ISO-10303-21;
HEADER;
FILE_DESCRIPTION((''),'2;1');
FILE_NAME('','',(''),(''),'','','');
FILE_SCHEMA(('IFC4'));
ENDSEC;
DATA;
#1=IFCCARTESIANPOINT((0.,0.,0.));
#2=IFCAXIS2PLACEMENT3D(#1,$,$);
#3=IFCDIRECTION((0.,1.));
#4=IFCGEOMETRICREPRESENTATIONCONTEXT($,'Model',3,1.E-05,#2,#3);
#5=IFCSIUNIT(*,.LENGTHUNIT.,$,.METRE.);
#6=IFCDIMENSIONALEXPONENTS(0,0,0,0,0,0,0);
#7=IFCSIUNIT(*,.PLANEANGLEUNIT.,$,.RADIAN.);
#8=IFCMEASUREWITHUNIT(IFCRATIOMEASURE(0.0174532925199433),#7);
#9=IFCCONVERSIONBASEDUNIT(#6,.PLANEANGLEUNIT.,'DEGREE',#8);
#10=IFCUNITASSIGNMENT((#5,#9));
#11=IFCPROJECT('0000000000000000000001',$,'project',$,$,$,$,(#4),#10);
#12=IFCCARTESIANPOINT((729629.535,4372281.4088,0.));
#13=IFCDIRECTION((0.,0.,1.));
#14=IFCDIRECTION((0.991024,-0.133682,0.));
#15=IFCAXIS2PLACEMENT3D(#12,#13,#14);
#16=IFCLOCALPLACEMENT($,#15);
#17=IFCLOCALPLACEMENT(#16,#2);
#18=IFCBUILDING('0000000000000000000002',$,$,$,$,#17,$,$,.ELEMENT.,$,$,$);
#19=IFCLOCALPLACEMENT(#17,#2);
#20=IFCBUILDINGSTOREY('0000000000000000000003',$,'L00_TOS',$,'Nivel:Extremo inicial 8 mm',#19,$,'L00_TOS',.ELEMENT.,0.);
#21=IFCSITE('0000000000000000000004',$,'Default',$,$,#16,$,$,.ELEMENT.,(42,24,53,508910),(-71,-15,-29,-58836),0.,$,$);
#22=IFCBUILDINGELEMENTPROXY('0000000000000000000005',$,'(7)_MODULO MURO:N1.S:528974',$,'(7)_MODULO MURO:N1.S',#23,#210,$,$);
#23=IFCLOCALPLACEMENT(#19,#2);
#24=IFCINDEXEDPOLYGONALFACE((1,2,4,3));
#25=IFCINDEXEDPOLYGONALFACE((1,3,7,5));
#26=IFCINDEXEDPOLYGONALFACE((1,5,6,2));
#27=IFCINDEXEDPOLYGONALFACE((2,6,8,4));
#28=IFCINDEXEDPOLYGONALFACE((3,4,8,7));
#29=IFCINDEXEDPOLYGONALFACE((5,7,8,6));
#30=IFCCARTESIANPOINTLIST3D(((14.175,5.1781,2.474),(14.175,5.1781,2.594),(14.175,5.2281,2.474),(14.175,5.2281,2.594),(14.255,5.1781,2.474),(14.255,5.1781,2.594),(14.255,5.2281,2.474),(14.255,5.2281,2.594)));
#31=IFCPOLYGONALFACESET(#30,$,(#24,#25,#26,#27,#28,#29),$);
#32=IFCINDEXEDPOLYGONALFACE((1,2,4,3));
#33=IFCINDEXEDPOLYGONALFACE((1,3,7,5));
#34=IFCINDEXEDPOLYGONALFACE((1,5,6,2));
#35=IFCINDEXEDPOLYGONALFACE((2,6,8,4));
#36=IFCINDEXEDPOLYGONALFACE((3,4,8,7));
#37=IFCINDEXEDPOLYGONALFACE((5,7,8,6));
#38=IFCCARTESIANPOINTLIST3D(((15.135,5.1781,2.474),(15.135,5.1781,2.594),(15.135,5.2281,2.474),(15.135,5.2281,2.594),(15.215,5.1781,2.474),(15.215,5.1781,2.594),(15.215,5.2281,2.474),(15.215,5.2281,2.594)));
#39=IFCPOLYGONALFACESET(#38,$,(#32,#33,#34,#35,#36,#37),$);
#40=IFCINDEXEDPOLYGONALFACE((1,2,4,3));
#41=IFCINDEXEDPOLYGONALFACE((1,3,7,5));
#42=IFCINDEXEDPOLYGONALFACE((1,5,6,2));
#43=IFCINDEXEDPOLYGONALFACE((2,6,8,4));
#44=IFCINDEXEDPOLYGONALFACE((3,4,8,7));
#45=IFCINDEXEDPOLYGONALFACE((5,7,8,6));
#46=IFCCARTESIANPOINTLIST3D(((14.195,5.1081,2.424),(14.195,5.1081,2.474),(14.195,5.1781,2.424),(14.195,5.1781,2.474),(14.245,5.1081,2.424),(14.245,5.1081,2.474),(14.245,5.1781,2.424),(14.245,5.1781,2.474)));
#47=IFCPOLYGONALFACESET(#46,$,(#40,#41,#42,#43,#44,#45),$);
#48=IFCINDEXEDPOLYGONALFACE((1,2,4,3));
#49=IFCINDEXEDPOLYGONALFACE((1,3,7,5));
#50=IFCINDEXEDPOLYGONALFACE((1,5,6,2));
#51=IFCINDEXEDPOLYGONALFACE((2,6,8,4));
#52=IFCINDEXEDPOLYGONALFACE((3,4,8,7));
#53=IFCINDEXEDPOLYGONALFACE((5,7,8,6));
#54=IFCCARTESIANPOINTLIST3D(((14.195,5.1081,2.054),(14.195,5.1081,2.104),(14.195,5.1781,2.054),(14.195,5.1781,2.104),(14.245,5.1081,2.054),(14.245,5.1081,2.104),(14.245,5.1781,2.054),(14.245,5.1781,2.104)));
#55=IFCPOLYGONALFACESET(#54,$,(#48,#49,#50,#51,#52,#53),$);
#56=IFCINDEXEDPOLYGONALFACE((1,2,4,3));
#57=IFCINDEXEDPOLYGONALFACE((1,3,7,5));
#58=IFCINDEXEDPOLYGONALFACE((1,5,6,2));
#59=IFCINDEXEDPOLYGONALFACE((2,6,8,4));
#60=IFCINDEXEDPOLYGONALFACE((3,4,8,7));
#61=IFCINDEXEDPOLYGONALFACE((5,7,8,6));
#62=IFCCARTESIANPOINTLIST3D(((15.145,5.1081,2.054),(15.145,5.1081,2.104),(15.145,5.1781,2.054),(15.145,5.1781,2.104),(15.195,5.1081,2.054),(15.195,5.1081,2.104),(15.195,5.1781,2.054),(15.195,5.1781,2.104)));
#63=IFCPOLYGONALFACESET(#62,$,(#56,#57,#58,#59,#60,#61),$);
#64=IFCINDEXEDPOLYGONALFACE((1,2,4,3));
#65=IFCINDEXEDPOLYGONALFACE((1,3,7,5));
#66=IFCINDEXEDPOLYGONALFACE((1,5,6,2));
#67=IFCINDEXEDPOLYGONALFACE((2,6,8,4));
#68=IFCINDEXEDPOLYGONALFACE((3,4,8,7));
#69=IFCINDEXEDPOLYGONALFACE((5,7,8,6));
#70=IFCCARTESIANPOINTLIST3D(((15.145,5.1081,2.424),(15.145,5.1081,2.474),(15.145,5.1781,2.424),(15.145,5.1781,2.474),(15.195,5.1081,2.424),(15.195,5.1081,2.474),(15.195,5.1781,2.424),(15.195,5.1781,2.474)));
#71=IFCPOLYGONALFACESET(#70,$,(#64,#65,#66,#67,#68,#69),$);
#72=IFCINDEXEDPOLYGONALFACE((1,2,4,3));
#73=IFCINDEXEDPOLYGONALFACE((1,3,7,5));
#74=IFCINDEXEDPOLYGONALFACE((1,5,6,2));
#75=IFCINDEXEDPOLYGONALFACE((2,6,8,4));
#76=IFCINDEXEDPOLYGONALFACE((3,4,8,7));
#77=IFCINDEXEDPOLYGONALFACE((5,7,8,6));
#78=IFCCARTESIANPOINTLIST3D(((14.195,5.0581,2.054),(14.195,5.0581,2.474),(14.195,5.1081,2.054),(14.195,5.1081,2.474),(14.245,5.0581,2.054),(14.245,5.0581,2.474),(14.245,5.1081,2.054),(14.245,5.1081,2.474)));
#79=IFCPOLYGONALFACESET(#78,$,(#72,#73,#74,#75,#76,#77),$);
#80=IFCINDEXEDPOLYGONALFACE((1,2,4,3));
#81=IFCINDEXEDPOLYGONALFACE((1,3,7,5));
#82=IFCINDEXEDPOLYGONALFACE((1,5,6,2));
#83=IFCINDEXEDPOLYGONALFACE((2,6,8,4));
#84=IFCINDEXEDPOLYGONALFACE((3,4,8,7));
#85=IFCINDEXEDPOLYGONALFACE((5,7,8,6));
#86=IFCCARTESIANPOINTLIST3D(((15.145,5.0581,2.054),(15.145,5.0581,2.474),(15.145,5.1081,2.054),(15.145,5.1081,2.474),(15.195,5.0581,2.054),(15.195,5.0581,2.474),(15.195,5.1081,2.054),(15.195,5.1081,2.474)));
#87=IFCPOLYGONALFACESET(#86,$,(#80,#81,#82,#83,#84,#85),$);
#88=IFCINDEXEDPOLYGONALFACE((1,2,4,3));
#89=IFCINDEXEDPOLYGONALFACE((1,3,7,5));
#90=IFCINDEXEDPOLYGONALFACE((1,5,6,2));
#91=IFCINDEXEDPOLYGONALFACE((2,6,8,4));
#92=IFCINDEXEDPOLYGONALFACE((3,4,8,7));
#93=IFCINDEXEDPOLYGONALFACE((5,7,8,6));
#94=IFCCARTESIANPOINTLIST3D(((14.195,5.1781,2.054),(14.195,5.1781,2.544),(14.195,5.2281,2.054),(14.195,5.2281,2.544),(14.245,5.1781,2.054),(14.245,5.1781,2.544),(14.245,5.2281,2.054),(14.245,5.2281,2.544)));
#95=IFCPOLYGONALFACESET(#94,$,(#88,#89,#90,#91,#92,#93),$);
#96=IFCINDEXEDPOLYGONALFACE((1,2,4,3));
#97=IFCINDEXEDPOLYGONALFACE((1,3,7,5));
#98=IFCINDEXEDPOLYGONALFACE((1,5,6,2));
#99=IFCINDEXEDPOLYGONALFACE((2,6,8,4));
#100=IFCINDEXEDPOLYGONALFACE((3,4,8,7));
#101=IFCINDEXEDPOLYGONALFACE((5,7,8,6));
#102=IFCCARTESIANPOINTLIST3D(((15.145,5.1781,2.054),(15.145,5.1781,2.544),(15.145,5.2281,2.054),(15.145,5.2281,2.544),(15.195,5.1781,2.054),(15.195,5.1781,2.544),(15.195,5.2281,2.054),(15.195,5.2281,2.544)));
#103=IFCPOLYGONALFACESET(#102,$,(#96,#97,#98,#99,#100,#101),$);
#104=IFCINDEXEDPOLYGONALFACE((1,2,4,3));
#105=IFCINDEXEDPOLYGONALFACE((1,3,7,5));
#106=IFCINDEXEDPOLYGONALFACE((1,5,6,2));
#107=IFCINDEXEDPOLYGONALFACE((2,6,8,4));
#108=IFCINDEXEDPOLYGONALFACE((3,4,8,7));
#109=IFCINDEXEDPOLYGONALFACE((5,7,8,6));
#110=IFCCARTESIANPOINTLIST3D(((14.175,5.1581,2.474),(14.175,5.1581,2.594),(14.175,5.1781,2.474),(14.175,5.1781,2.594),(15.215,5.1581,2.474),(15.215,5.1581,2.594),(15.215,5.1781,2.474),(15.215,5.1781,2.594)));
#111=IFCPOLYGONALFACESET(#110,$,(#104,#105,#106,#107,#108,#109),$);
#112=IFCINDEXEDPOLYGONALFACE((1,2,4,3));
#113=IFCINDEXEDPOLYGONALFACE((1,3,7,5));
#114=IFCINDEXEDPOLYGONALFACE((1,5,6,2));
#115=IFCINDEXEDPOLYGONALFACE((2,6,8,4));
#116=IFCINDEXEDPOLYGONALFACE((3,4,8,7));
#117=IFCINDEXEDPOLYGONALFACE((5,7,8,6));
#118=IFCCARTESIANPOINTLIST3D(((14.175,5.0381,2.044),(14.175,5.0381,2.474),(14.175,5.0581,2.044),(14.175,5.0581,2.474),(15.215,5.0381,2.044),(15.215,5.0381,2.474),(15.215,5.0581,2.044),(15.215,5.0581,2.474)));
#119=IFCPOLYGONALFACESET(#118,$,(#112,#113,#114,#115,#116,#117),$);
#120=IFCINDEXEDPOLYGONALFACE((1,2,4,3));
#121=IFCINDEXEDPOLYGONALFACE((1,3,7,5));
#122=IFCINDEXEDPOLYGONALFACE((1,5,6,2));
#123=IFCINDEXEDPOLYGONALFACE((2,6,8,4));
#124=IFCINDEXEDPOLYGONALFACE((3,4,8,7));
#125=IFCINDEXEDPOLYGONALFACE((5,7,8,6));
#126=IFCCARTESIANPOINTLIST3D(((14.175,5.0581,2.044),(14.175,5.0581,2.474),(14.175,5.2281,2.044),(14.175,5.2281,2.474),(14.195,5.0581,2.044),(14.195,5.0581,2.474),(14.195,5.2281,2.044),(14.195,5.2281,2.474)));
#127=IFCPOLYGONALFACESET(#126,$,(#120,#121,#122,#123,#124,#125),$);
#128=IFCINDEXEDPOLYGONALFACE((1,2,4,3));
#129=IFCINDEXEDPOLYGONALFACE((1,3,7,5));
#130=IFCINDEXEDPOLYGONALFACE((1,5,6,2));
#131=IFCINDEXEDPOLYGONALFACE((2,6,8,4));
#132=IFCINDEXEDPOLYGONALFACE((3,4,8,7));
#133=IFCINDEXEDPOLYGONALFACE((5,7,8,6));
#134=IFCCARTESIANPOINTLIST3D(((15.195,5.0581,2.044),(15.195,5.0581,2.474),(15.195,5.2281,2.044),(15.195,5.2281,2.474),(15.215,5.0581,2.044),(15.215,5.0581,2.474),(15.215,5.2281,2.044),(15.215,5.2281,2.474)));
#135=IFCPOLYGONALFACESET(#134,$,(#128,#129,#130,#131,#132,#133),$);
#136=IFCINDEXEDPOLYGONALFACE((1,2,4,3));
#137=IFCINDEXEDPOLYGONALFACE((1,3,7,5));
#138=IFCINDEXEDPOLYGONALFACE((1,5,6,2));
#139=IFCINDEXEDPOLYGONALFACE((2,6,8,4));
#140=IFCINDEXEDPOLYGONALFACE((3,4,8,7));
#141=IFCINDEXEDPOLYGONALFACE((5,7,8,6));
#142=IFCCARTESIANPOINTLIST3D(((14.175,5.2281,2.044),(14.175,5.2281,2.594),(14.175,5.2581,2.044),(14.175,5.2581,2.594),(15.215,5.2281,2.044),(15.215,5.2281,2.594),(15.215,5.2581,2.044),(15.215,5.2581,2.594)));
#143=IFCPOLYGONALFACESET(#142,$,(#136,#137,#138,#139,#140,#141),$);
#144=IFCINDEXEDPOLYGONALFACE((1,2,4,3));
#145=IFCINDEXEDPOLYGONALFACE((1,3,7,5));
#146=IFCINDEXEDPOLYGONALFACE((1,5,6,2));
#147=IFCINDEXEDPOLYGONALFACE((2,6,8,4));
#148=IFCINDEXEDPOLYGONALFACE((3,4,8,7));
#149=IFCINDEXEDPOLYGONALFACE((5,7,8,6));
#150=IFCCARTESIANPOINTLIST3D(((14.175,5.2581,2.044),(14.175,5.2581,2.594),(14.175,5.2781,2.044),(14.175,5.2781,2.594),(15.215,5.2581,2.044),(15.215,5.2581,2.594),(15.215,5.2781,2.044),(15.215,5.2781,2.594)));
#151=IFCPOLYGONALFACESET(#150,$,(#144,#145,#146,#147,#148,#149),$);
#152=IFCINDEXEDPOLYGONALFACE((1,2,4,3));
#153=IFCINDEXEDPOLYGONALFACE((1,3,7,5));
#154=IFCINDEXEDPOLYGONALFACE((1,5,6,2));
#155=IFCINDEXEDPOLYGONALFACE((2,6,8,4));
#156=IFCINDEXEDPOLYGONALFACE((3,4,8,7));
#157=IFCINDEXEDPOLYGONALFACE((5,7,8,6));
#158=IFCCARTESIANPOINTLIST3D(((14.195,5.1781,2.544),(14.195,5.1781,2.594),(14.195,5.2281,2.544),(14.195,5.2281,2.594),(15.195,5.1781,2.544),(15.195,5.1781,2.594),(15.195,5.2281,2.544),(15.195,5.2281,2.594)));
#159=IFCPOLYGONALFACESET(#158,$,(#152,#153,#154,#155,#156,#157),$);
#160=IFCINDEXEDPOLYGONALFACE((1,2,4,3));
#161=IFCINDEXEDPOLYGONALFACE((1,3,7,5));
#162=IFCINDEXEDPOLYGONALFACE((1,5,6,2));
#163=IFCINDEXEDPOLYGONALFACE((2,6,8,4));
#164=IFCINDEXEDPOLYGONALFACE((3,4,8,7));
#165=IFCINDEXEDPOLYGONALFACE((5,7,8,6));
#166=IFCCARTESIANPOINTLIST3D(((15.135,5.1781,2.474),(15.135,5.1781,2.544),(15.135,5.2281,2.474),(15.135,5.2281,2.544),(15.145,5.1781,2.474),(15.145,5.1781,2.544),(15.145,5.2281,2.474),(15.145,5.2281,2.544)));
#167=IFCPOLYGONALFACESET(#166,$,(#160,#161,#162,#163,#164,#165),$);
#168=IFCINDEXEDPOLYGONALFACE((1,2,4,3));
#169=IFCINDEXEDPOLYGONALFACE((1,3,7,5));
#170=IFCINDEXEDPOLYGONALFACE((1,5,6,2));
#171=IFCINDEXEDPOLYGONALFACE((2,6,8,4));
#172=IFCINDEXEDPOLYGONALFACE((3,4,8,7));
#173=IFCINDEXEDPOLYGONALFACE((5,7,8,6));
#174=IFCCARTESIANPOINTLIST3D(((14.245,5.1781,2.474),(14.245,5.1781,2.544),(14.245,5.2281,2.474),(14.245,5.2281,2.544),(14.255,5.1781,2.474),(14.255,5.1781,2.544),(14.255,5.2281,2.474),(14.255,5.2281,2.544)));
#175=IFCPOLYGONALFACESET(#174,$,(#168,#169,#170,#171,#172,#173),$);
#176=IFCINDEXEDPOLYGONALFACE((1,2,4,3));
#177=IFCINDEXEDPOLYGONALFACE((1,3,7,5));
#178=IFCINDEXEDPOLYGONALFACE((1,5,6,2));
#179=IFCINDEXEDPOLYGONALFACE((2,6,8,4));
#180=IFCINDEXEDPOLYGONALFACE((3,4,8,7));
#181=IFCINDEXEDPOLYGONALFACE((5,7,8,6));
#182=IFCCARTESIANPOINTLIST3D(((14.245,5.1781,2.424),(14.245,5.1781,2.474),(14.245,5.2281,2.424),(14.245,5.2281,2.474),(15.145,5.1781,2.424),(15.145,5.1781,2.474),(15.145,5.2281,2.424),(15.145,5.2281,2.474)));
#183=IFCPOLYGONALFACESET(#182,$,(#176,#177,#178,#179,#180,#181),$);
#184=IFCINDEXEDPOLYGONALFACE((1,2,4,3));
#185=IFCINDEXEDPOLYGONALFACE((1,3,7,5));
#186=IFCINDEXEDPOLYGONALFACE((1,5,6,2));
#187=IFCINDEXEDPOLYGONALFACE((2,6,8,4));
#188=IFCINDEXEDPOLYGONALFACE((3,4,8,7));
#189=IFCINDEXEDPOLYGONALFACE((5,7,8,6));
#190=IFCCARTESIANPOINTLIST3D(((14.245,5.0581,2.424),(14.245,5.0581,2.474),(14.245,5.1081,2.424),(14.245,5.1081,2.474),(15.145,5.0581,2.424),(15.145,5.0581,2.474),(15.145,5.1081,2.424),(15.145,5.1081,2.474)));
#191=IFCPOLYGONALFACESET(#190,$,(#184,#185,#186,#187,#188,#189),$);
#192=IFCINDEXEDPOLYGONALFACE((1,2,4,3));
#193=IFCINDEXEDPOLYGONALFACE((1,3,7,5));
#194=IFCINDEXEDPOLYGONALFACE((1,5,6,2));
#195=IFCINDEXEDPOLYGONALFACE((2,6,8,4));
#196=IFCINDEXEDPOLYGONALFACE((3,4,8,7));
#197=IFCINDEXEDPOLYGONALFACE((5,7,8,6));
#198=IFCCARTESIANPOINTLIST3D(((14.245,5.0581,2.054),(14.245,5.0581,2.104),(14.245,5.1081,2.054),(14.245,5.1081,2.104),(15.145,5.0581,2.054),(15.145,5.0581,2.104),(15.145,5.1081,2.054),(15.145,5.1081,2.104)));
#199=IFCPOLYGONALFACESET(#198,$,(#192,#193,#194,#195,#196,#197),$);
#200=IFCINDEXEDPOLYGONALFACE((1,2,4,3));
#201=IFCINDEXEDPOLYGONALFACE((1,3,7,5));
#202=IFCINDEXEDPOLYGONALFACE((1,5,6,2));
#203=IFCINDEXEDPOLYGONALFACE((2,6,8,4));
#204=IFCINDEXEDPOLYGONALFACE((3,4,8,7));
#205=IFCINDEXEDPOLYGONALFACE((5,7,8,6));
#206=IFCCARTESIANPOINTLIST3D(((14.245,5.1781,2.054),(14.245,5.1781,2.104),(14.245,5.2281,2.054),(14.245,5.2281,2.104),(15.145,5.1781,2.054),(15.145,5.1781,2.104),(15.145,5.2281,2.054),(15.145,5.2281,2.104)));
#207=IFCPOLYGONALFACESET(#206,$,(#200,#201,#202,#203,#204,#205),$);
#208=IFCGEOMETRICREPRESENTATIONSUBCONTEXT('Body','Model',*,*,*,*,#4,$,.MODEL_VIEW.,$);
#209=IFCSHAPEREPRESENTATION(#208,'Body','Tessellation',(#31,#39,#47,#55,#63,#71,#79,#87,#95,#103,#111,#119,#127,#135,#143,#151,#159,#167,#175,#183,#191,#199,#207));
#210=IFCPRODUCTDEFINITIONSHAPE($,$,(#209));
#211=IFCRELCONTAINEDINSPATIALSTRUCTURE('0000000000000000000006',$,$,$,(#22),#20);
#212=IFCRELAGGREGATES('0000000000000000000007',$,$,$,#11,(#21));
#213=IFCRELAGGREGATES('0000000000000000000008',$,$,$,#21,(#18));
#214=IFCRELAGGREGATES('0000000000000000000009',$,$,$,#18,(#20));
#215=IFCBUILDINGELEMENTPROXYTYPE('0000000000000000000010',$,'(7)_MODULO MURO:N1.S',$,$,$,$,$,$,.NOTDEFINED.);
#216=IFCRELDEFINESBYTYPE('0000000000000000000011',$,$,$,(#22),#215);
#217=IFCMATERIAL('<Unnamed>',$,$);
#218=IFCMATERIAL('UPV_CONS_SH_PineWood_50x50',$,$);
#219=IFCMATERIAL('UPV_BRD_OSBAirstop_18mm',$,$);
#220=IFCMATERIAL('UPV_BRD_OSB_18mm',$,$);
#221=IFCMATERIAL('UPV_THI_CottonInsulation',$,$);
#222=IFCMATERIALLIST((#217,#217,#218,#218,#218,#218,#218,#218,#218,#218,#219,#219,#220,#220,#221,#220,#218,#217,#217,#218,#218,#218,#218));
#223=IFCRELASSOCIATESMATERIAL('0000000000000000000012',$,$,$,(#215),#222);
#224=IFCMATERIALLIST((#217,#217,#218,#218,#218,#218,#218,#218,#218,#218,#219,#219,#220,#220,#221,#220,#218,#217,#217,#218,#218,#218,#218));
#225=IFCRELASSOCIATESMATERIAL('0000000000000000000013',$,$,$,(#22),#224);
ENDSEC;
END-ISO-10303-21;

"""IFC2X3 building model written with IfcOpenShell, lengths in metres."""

from ifc_helpers import new_model, entity, si_unit, converted_unit, direction, frame, frame_2d, origin, origin_2d_with_axis, place, context, subcontext, project, spatial, rectangle, extrude, source, transform, mapped, material, material_list, type_object, type_shapes, element, save


model = new_model("IFC2X3")

# Units and contexts
model_context = context("Model", 3, precision=1e-05, world=origin(), true_north=direction((0.0, 1.0)))
body_context = subcontext(model_context, "Body", "Model", "MODEL_VIEW")
ifc_project = project(units=[si_unit("LENGTHUNIT", "METRE"), converted_unit("PLANEANGLEUNIT", "DEGREE", entity("IfcRatioMeasure", 0.0174532925199433), si_unit("PLANEANGLEUNIT", "RADIAN"), dimensions=[0, 0, 0, 0, 0, 0, 0])], contexts=[model_context])

# Site, building, storey
site_placement = place(None, frame((729629.535, 4372281.4088, 0.0), z_axis=(0.0, 0.0, 1.0), x_axis=(0.991024, -0.133682, 0.0)))
site = spatial("IfcSite", under=ifc_project, at=site_placement, Name="Default", CompositionType="ELEMENT", RefLatitude=(42, 24, 53, 508910), RefLongitude=(-71, -15, -29, -58836), RefElevation=0.0)
building_placement = place(site_placement, origin())
building = spatial("IfcBuilding", under=site, at=building_placement, CompositionType="ELEMENT")
storey_placement = place(building_placement, origin())
storey = spatial("IfcBuildingStorey", under=building, at=storey_placement, Name="L00_TOS", ObjectType="Nivel:Extremo inicial 8 mm", LongName="L00_TOS", CompositionType="ELEMENT", Elevation=0.0)

# Building element proxy
ifc_material_1 = material(Name="UPV_BRD_OSBAirstop_18mm")
ifc_material_2 = material(Name="UPV_BRD_OSB_18mm")
ifc_material_3 = material(Name="UPV_THI_CottonInsulation")
ifc_material_4 = material(Name="<Unnamed>")
ifc_material_5 = material(Name="UPV_CONS_SH_PineWood_50x50")
ifc_material_list_1 = material_list([ifc_material_4, ifc_material_4, ifc_material_5, ifc_material_5, ifc_material_5, ifc_material_5, ifc_material_5, ifc_material_5, ifc_material_5, ifc_material_5, ifc_material_1, ifc_material_1, ifc_material_2, ifc_material_2, ifc_material_3, ifc_material_2, ifc_material_5, ifc_material_4, ifc_material_4, ifc_material_5, ifc_material_5, ifc_material_5, ifc_material_5])
ifc_material_list_2 = material_list([ifc_material_4, ifc_material_4, ifc_material_5, ifc_material_5, ifc_material_5, ifc_material_5, ifc_material_5, ifc_material_5, ifc_material_5, ifc_material_5, ifc_material_1, ifc_material_1, ifc_material_2, ifc_material_2, ifc_material_3, ifc_material_2, ifc_material_5, ifc_material_4, ifc_material_4, ifc_material_5, ifc_material_5, ifc_material_5, ifc_material_5])
building_element_proxy_type_1 = type_object("IfcBuildingElementProxyType", Name="(7)_MODULO MURO:N1.S", PredefinedType="NOTDEFINED", material=ifc_material_list_2)
shared_shape_1 = source(origin(), body_context, "Body", "SweptSolid", [
    extrude(rectangle(XDim=0.08, YDim=0.05, at=frame_2d((0.0, 0.0), x_axis=(1.0, 0.0))), frame((-0.48, 0.025, 2.05), z_axis=(0.0, 0.0, 1.0), x_axis=(-1.0, 0.0, 0.0)), (0.0, 0.0, 1.0), 0.12),
    extrude(rectangle(XDim=0.08, YDim=0.05, at=frame_2d((0.0, 0.0), x_axis=(1.0, 0.0))), frame((0.48, 0.025, 2.05), z_axis=(0.0, 0.0, 1.0), x_axis=(-1.0, 0.0, 0.0)), (0.0, 0.0, 1.0), 0.12),
    extrude(rectangle(XDim=0.07, YDim=0.05, at=frame_2d((0.0, 0.0), x_axis=(1.0, 0.0))), frame((-0.475, -0.035, 2.0), z_axis=(0.0, 0.0, 1.0), x_axis=(0.0, 1.0, 0.0)), (0.0, 0.0, 1.0), 0.05),
    extrude(rectangle(XDim=0.07, YDim=0.05, at=frame_2d((0.0, 0.0), x_axis=(1.0, 0.0))), frame((-0.475, -0.035, 1.63), z_axis=(0.0, 0.0, 1.0), x_axis=(0.0, 1.0, 0.0)), (0.0, 0.0, 1.0), 0.05),
    extrude(rectangle(XDim=0.07, YDim=0.05, at=origin_2d_with_axis()), frame((0.475, -0.035, 1.63), z_axis=(0.0, 0.0, 1.0), x_axis=(0.0, 1.0, 0.0)), (0.0, 0.0, 1.0), 0.05),
    extrude(rectangle(XDim=0.07, YDim=0.05, at=origin_2d_with_axis()), frame((0.475, -0.035, 2.0), z_axis=(0.0, 0.0, 1.0), x_axis=(0.0, 1.0, 0.0)), (0.0, 0.0, 1.0), 0.05),
    extrude(rectangle(XDim=0.05, YDim=0.05, at=frame_2d((0.0, 0.0), x_axis=(1.0, 0.0))), frame((-0.475, -0.095, 1.63), z_axis=(0.0, 0.0, 1.0), x_axis=(0.0, -1.0, 0.0)), (0.0, 0.0, 1.0), 0.42),
    extrude(rectangle(XDim=0.05, YDim=0.05, at=frame_2d((0.0, 0.0), x_axis=(1.0, 0.0))), frame((0.475, -0.095, 1.63), z_axis=(0.0, 0.0, 1.0), x_axis=(0.0, -1.0, 0.0)), (0.0, 0.0, 1.0), 0.42),
    extrude(rectangle(XDim=0.05, YDim=0.05, at=frame_2d((0.0, 0.0), x_axis=(1.0, 0.0))), frame((-0.475, 0.025, 1.63), z_axis=(0.0, 0.0, 1.0), x_axis=(0.0, -1.0, 0.0)), (0.0, 0.0, 1.0), 0.49),
    extrude(rectangle(XDim=0.05, YDim=0.05, at=frame_2d((0.0, 0.0), x_axis=(1.0, 0.0))), frame((0.475, 0.025, 1.63), z_axis=(0.0, 0.0, 1.0), x_axis=(0.0, -1.0, 0.0)), (0.0, 0.0, 1.0), 0.49),
    extrude(rectangle(XDim=1.04, YDim=0.02, at=origin_2d_with_axis()), frame((0.0, -0.01, 2.05), z_axis=(0.0, 0.0, 1.0), x_axis=(-1.0, 0.0, 0.0)), (0.0, 0.0, 1.0), 0.12),
    extrude(rectangle(XDim=1.04, YDim=0.02, at=origin_2d_with_axis()), frame((0.0, -0.13, 1.62)), (0.0, 0.0, 1.0), 0.43),
    extrude(rectangle(XDim=0.17, YDim=0.02, at=frame_2d((0.0, 0.0), x_axis=(1.0, 0.0))), frame((-0.51, -0.035, 1.62), z_axis=(0.0, 0.0, 1.0), x_axis=(0.0, -1.0, 0.0)), (0.0, 0.0, 1.0), 0.43),
    extrude(rectangle(XDim=0.17, YDim=0.02, at=frame_2d((0.0, 0.0), x_axis=(1.0, 0.0))), frame((0.51, -0.035, 1.62), z_axis=(0.0, 0.0, 1.0), x_axis=(0.0, -1.0, 0.0)), (0.0, 0.0, 1.0), 0.43),
    extrude(rectangle(XDim=0.03, YDim=1.04, at=origin_2d_with_axis()), frame((0.0, 0.065, 1.62), z_axis=(0.0, 0.0, 1.0), x_axis=(0.0, 1.0, 0.0)), (0.0, 0.0, 1.0), 0.55),
    extrude(rectangle(XDim=0.02, YDim=1.04, at=origin_2d_with_axis()), frame((0.0, 0.09, 1.62), z_axis=(0.0, 0.0, 1.0), x_axis=(0.0, 1.0, 0.0)), (0.0, 0.0, 1.0), 0.55),
    extrude(rectangle(XDim=1.0, YDim=0.05, at=frame_2d((0.0, 0.0), x_axis=(1.0, 0.0))), frame((0.0, 0.025, 2.12), z_axis=(0.0, 0.0, 1.0), x_axis=(-1.0, 0.0, 0.0)), (0.0, 0.0, 1.0), 0.05),
    extrude(rectangle(XDim=0.01, YDim=0.05, at=frame_2d((0.0, 0.0), x_axis=(1.0, 0.0))), frame((0.445, 0.025, 2.05), z_axis=(0.0, 0.0, 1.0), x_axis=(-1.0, 0.0, 0.0)), (0.0, 0.0, 1.0), 0.07),
    extrude(rectangle(XDim=0.05, YDim=0.01, at=frame_2d((0.0, 0.0), x_axis=(1.0, 0.0))), frame((-0.445, 0.025, 2.05), z_axis=(0.0, 0.0, 1.0), x_axis=(0.0, 1.0, 0.0)), (0.0, 0.0, 1.0), 0.07),
    extrude(rectangle(XDim=0.9, YDim=0.05, at=origin_2d_with_axis()), frame((0.0, 0.025, 2.0), z_axis=(0.0, 0.0, 1.0), x_axis=(-1.0, 0.0, 0.0)), (0.0, 0.0, 1.0), 0.05),
    extrude(rectangle(XDim=0.9, YDim=0.05, at=frame_2d((0.0, 0.0), x_axis=(1.0, 0.0))), frame((0.0, -0.095, 2.0), z_axis=(0.0, 0.0, 1.0), x_axis=(-1.0, 0.0, 0.0)), (0.0, 0.0, 1.0), 0.05),
    extrude(rectangle(XDim=0.9, YDim=0.05, at=frame_2d((0.0, 0.0), x_axis=(1.0, 0.0))), frame((0.0, -0.095, 1.63), z_axis=(0.0, 0.0, 1.0), x_axis=(-1.0, 0.0, 0.0)), (0.0, 0.0, 1.0), 0.05),
    extrude(rectangle(XDim=0.9, YDim=0.05, at=origin_2d_with_axis()), frame((0.0, 0.025, 1.63), z_axis=(0.0, 0.0, 1.0), x_axis=(-1.0, 0.0, 0.0)), (0.0, 0.0, 1.0), 0.05),
])
type_shapes(building_element_proxy_type_1, [shared_shape_1])
proxy_1_placement = place(storey_placement, frame((14.695, 5.1781, 0.424)))
element("IfcBuildingElementProxy", 1, at=proxy_1_placement, inside=storey, type_object=building_element_proxy_type_1, material=ifc_material_list_1, Name="(7)_MODULO MURO:N1.S:528974", ObjectType="(7)_MODULO MURO:N1.S", context=body_context, shape_type="MappedRepresentation", body=[
    mapped(shared_shape_1, transform((0.0, 0.0, 0.0), scale=1.0)),
])

save(model, "model.ifc")
